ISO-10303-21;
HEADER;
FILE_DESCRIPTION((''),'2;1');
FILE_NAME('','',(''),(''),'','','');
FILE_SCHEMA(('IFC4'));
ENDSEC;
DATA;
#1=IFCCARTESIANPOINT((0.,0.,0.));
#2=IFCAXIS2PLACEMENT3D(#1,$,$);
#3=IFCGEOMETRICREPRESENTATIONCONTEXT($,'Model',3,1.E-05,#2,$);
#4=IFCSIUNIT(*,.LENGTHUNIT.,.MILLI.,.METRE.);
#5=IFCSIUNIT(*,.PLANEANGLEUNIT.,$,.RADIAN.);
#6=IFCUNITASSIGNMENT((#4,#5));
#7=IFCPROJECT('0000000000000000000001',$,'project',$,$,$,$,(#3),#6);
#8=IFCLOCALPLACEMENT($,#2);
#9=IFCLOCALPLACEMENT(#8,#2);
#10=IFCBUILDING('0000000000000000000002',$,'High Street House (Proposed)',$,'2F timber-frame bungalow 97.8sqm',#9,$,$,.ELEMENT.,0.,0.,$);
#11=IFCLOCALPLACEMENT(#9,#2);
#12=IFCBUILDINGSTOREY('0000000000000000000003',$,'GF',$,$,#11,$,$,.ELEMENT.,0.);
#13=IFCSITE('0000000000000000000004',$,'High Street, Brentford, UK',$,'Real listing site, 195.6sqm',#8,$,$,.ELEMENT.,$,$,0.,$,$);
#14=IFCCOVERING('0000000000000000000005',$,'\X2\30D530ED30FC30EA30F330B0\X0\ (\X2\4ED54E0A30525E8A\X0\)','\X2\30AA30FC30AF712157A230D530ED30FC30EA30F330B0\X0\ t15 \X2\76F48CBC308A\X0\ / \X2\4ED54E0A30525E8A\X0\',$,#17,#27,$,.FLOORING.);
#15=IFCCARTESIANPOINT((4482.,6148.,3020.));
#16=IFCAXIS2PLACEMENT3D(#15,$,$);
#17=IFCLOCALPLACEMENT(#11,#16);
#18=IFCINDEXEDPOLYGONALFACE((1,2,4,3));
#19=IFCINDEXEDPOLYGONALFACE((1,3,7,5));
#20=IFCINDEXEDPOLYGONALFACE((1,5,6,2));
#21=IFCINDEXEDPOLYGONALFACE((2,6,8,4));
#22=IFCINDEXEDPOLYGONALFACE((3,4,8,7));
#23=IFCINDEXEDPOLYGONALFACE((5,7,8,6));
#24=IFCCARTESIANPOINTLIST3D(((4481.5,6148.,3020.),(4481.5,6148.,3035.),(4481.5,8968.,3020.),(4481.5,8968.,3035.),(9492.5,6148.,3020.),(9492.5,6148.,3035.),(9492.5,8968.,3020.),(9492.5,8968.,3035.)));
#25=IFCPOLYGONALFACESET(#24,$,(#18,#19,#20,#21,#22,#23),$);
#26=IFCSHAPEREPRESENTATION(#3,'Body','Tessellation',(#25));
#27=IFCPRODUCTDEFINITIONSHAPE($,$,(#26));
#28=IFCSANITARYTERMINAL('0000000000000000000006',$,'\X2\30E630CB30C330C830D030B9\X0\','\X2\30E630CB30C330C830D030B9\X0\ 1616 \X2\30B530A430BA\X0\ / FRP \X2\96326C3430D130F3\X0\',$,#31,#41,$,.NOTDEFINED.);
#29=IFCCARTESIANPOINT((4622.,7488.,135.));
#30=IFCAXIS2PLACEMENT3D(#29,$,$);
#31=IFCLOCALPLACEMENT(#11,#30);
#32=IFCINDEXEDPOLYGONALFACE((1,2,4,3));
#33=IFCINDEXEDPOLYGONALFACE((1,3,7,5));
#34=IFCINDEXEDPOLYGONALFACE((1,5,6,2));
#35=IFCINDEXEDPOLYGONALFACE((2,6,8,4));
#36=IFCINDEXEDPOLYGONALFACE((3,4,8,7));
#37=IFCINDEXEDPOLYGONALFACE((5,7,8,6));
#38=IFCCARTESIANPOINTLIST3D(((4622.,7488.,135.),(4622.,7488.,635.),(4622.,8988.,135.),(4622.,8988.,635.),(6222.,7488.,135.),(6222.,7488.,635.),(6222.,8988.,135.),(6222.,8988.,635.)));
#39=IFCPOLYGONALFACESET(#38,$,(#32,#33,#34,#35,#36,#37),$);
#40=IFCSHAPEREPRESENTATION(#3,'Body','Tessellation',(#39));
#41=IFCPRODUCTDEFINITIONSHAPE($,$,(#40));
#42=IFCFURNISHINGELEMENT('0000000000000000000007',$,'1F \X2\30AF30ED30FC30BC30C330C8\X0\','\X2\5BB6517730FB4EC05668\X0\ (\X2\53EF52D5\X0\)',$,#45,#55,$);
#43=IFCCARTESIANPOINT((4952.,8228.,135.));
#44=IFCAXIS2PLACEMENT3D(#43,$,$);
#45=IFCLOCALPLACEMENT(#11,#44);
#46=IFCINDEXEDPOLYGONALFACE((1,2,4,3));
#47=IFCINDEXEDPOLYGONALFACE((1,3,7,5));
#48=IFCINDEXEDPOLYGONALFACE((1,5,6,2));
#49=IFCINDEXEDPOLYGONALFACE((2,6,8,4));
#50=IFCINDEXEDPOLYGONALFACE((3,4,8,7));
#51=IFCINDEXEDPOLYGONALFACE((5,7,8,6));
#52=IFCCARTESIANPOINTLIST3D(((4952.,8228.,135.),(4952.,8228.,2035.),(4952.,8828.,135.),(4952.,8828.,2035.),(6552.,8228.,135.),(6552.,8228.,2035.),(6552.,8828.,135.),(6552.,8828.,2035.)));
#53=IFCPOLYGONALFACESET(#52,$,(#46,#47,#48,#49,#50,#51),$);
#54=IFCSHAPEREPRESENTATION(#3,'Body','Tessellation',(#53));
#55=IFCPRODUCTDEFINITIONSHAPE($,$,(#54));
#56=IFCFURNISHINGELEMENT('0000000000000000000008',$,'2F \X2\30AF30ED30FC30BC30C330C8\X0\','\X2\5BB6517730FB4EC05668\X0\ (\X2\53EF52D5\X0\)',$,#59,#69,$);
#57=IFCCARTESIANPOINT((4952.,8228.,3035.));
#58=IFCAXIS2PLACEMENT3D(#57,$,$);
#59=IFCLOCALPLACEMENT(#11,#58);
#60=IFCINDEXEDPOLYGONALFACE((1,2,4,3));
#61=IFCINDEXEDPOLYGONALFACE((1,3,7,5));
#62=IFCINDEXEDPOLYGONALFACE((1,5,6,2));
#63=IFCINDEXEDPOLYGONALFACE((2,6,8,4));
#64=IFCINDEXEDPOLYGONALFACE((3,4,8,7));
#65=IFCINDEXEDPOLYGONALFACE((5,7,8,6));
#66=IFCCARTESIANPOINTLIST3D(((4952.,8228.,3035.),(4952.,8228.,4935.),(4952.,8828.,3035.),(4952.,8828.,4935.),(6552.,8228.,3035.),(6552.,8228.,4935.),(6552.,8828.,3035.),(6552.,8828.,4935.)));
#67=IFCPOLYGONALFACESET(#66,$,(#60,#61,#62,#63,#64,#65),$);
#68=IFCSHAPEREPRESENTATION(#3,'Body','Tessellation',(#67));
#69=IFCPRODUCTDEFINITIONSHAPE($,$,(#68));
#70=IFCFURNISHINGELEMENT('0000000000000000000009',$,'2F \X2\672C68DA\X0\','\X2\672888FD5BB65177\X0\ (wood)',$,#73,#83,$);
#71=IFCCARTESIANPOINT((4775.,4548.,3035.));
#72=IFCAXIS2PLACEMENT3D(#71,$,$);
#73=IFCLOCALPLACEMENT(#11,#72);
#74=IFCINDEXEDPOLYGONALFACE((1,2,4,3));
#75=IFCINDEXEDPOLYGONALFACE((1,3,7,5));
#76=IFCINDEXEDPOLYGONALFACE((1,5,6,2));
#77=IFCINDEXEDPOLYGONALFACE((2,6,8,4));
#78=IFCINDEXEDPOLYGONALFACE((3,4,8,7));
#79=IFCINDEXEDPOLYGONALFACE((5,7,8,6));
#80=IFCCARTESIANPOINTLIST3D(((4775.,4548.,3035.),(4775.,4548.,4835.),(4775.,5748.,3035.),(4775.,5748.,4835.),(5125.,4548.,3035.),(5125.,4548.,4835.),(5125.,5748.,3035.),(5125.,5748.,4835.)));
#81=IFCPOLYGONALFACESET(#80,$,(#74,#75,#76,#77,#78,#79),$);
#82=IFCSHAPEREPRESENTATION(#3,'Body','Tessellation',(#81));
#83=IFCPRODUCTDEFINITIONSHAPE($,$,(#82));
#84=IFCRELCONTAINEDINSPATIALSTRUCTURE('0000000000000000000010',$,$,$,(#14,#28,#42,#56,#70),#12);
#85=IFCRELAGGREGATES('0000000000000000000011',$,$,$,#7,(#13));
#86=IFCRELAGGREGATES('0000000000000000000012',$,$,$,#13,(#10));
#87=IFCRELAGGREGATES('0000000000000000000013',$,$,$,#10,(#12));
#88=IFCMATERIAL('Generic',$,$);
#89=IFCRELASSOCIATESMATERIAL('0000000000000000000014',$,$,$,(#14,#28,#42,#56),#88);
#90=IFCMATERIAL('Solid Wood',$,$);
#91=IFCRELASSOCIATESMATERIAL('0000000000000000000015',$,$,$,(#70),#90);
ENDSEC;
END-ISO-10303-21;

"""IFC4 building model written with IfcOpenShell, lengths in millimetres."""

from ifc_helpers import new_model, si_unit, frame, frame_2d, origin, place, context, project, spatial, rectangle, extrude, material, element, save


model = new_model("IFC4")

# Units and contexts
model_context = context("Model", 3, precision=1e-05, world=origin())
ifc_project = project(units=[si_unit("LENGTHUNIT", "METRE", prefix="MILLI"), si_unit("PLANEANGLEUNIT", "RADIAN")], contexts=[model_context])

# Site, building, storey
site_placement = place(None, origin())
site = spatial("IfcSite", under=ifc_project, at=site_placement, Name="High Street, Brentford, UK", ObjectType="Real listing site, 195.6sqm", CompositionType="ELEMENT", RefElevation=0.0)
building_placement = place(site_placement, origin())
building = spatial("IfcBuilding", under=site, at=building_placement, Name="High Street House (Proposed)", ObjectType="2F timber-frame bungalow 97.8sqm", CompositionType="ELEMENT", ElevationOfRefHeight=0.0, ElevationOfTerrain=0.0)
storey_placement = place(building_placement, origin())
storey = spatial("IfcBuildingStorey", under=building, at=storey_placement, Name="GF", CompositionType="ELEMENT", Elevation=0.0)

# Shared definitions
ifc_material_1 = material(Name="Solid Wood")

# Covering
ifc_material_2 = material(Name="Generic")
covering_1_placement = place(storey_placement, frame((4482.0, 6148.0, 3020.0)))
element("IfcCovering", 1, at=covering_1_placement, inside=storey, material=ifc_material_2, Name="フローリング (仕上げ床)", Description="オーク無垢フローリング t15 直貼り / 仕上げ床", PredefinedType="FLOORING", context=model_context, shape_type="SweptSolid", body=[
    extrude(rectangle(XDim=5011.0, YDim=2820.0, at=frame_2d((2505.0, 1410.0))), frame((4482.0, 6148.0, 3020.0)), (0.0, 0.0, 1.0), 15.0),
])

# Sanitary terminal
sanitary_terminal_placement = place(storey_placement, frame((4622.0, 7488.0, 135.0)))
element("IfcSanitaryTerminal", 2, at=sanitary_terminal_placement, inside=storey, material=ifc_material_2, Name="ユニットバス", Description="ユニットバス 1616 サイズ / FRP 防水パン", PredefinedType="NOTDEFINED", context=model_context, shape_type="SweptSolid", body=[
    extrude(rectangle(XDim=1600.0, YDim=1500.0, at=frame_2d((800.0, 750.0))), frame((4622.0, 7488.0, 135.0)), (0.0, 0.0, 1.0), 500.0),
])

# Furnishing elements
furnishing_1_placement = place(storey_placement, frame((4952.0, 8228.0, 135.0)))
element("IfcFurnishingElement", 3, at=furnishing_1_placement, inside=storey, material=ifc_material_2, Name="1F クローゼット", Description="家具・什器 (可動)", context=model_context, shape_type="SweptSolid", body=[
    extrude(rectangle(XDim=1600.0, YDim=600.0, at=frame_2d((800.0, 300.0))), frame((4952.0, 8228.0, 135.0)), (0.0, 0.0, 1.0), 1900.0),
])
furnishing_2_placement = place(storey_placement, frame((4952.0, 8228.0, 3035.0)))
element("IfcFurnishingElement", 4, at=furnishing_2_placement, inside=storey, material=ifc_material_2, Name="2F クローゼット", Description="家具・什器 (可動)", context=model_context, shape_type="SweptSolid", body=[
    extrude(rectangle(XDim=1600.0, YDim=600.0, at=frame_2d((800.0, 300.0))), frame((4952.0, 8228.0, 3035.0)), (0.0, 0.0, 1.0), 1900.0),
])
furnishing_3_placement = place(storey_placement, frame((4775.0, 4548.0, 3035.0)))
element("IfcFurnishingElement", 5, at=furnishing_3_placement, inside=storey, material=ifc_material_1, Name="2F 本棚", Description="木製家具 (wood)", context=model_context, shape_type="SweptSolid", body=[
    extrude(rectangle(XDim=350.0, YDim=1200.0, at=frame_2d((175.0, 600.0))), frame((4775.0, 4548.0, 3035.0)), (0.0, 0.0, 1.0), 1800.0),
])

save(model, "model.ifc")
